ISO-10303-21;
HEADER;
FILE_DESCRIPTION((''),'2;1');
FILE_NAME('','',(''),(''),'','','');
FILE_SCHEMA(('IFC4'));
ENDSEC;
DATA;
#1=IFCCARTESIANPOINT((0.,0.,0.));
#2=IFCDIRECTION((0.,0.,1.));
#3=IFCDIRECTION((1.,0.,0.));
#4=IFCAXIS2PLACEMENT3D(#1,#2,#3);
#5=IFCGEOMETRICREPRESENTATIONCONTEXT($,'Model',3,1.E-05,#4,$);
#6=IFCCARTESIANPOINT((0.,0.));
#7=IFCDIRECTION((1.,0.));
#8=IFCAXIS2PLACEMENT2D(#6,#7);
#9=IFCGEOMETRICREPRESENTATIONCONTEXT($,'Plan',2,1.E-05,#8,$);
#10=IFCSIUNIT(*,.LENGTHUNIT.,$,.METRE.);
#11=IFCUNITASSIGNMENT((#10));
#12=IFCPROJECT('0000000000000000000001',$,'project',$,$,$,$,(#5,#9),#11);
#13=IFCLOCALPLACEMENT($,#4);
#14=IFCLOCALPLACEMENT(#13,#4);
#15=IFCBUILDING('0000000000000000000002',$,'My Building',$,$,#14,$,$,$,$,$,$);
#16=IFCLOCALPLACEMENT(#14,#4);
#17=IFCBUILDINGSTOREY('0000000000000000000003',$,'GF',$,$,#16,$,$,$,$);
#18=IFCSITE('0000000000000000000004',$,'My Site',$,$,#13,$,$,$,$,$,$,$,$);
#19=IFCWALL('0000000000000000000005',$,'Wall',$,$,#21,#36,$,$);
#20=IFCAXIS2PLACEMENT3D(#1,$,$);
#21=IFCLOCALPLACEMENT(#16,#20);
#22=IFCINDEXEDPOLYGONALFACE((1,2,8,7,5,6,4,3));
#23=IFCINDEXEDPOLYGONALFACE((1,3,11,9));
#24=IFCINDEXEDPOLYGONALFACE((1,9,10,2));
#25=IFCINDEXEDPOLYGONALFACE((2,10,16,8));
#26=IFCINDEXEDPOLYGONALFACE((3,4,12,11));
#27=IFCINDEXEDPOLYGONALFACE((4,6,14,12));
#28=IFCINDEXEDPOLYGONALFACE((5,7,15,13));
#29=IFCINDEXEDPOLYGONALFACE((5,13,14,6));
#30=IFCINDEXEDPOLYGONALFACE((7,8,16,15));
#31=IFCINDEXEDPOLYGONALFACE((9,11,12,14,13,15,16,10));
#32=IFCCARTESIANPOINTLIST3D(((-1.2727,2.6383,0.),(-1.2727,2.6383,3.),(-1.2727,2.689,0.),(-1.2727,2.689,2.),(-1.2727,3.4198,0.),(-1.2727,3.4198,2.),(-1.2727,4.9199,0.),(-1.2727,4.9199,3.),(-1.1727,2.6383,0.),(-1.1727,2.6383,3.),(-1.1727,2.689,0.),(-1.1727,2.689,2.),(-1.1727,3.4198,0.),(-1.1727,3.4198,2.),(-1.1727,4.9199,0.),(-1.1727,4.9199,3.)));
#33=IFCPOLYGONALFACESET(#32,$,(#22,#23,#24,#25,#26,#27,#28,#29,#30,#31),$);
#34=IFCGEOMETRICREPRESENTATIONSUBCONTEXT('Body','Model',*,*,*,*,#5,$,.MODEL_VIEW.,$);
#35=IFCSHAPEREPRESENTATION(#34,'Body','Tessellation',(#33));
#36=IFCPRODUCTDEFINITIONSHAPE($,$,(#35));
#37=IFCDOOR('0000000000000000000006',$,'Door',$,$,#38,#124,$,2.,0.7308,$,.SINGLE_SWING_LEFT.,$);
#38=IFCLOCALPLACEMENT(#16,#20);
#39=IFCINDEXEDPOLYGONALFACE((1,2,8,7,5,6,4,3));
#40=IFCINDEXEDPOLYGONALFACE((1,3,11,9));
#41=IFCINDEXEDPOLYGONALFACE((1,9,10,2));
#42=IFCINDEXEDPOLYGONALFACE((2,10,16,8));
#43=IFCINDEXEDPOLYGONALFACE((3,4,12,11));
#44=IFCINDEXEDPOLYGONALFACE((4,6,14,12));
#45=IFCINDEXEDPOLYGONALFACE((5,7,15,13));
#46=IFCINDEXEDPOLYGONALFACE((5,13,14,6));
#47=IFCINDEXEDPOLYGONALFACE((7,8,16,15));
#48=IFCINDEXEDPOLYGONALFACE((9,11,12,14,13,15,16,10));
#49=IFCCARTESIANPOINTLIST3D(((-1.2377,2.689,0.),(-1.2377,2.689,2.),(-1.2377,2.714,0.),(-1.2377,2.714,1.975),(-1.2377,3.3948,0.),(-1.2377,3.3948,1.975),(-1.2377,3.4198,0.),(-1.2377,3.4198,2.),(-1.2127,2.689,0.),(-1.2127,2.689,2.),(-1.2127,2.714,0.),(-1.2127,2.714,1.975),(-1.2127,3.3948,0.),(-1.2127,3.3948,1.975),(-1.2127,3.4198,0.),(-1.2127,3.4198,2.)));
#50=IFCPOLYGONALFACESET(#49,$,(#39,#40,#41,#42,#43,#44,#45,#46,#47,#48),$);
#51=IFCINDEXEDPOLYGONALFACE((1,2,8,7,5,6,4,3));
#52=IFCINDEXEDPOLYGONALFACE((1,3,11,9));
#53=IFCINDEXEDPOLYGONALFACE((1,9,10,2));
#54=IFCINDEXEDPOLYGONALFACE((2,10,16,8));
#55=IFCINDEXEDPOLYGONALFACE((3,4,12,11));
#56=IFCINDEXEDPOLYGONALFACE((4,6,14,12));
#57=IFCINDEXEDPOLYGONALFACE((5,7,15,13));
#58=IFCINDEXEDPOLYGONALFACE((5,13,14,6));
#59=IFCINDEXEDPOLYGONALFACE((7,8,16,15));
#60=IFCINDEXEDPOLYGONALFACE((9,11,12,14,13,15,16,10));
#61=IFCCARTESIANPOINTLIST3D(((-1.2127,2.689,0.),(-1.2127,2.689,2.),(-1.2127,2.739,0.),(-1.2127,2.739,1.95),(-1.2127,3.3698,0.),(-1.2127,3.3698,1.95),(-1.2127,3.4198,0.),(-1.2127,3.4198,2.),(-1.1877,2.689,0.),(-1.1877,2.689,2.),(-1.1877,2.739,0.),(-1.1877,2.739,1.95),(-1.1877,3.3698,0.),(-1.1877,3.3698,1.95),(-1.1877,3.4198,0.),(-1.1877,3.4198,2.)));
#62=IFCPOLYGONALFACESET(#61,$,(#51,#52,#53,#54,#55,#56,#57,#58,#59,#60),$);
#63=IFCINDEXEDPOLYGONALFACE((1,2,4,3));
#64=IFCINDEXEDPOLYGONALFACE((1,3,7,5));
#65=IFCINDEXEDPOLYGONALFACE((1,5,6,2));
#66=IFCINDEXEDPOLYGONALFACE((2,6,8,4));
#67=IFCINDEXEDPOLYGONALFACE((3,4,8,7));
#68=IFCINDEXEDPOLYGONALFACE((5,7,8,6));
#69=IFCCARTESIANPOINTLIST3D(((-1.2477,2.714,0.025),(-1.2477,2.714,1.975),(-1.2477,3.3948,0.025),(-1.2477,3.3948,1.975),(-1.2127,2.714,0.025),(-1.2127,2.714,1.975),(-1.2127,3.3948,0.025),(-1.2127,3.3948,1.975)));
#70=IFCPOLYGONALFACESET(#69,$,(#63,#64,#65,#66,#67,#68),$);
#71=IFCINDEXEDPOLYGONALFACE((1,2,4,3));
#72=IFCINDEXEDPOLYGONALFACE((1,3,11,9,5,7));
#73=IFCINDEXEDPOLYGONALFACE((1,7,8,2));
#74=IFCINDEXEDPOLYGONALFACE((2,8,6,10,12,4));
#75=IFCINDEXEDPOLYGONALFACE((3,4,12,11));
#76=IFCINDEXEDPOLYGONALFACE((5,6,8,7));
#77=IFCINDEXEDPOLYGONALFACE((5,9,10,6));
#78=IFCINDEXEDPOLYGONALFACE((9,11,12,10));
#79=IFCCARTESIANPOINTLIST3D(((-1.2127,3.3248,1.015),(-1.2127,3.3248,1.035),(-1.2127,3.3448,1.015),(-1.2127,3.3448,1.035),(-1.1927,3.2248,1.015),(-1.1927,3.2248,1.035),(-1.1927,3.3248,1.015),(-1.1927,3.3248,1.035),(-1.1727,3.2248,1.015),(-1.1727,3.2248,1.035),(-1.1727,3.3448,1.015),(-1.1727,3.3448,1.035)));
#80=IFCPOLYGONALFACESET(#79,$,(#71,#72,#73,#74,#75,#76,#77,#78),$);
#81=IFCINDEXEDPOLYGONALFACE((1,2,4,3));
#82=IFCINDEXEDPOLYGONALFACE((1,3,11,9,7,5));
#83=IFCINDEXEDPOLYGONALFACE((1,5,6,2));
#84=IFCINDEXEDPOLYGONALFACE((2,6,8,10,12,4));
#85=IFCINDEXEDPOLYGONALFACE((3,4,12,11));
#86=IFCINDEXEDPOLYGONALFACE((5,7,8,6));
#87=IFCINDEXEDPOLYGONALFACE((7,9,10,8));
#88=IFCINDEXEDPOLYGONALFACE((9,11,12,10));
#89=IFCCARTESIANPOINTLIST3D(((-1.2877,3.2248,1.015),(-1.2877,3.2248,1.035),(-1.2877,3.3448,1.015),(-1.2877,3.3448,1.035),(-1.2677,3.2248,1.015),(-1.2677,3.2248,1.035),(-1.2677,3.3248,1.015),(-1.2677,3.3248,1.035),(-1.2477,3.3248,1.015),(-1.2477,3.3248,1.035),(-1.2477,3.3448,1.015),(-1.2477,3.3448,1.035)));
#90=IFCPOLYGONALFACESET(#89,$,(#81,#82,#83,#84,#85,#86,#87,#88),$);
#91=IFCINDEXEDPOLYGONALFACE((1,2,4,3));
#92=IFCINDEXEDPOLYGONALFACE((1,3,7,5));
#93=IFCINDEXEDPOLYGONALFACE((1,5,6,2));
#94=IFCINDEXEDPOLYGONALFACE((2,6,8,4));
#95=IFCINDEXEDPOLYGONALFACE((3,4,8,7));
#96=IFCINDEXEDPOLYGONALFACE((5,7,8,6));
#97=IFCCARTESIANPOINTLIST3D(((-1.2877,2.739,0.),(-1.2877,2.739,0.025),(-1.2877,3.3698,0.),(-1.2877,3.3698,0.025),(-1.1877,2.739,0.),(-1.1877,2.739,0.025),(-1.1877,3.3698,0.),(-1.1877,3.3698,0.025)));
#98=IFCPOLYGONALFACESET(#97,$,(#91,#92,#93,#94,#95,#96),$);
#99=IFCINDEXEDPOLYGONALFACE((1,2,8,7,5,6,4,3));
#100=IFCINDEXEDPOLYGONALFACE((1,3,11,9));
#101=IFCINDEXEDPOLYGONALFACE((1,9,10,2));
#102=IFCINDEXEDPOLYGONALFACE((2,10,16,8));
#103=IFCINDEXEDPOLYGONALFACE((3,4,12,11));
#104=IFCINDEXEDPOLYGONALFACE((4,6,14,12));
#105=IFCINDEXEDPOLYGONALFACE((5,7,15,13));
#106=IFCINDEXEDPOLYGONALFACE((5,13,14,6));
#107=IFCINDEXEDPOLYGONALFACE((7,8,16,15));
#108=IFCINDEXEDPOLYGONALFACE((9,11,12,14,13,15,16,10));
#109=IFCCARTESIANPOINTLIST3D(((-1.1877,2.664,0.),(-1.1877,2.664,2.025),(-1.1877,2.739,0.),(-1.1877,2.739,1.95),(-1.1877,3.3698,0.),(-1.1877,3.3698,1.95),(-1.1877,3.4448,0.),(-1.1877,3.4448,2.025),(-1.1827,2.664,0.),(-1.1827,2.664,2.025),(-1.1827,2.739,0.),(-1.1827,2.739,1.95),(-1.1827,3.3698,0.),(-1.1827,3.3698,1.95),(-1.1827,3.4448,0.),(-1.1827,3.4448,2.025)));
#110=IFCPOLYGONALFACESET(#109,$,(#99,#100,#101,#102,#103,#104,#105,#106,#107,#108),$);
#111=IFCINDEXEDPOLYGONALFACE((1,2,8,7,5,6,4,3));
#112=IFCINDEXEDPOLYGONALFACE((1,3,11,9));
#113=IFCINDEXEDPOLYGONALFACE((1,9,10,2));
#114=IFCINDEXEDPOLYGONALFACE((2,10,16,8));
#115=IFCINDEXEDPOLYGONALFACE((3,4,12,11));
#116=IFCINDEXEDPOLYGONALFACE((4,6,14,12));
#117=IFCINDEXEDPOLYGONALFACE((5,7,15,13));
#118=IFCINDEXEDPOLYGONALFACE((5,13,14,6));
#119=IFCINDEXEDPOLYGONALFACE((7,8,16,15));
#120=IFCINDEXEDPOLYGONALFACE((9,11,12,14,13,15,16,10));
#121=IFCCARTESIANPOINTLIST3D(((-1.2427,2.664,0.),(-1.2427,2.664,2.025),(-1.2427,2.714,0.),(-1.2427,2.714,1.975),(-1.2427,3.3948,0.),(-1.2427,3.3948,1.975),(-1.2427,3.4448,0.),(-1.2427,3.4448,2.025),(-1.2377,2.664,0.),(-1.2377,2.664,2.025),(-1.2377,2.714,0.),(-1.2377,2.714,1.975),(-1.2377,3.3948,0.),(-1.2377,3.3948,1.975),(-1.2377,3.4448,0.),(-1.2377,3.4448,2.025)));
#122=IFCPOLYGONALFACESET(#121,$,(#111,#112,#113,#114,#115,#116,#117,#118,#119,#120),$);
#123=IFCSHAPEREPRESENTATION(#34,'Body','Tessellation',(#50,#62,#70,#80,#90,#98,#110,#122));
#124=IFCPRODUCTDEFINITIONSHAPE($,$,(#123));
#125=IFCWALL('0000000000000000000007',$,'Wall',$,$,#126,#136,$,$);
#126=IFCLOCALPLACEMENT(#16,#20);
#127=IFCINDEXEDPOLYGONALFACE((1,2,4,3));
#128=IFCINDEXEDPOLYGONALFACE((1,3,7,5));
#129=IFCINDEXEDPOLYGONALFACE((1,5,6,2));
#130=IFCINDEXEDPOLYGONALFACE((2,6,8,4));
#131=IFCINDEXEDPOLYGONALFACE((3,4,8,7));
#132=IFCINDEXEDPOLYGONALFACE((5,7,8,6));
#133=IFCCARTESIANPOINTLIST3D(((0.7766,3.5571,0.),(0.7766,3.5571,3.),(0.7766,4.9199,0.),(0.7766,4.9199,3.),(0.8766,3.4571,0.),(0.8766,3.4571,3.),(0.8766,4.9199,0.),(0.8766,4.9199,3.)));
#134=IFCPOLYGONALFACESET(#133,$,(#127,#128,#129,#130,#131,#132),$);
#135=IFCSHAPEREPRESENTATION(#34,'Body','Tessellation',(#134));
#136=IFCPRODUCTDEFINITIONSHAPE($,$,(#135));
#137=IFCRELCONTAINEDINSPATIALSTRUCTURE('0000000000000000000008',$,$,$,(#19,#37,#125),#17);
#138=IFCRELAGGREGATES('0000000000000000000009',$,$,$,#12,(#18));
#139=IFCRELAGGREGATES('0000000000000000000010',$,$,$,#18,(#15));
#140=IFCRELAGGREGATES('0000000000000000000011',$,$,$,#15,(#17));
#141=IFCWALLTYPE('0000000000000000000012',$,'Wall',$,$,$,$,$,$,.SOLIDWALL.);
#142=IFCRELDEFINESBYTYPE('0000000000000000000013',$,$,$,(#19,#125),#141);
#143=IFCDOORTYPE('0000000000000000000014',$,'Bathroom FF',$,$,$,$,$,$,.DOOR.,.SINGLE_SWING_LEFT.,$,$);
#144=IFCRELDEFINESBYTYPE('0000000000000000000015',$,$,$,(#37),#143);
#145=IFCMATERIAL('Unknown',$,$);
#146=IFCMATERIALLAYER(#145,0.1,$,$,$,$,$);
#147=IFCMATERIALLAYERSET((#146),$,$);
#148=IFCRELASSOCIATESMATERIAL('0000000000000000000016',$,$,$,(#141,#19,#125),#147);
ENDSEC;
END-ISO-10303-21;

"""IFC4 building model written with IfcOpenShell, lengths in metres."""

from ifc_helpers import new_model, entity, si_unit, frame, origin_with_axes, origin_2d_with_axis, place, context, subcontext, project, spatial, line, indexed_curve, outline, extrude, shape, source, transform, mapped, material, layer, layer_set, layer_usage, type_object, type_shapes, element, fill, save


model = new_model("IFC4")

# Units and contexts
model_context = context("Model", 3, precision=1e-05, world=origin_with_axes())
plan_context = context("Plan", 2, precision=1e-05, world=origin_2d_with_axis())
body_context_1 = subcontext(model_context, "Body", "Model", "MODEL_VIEW")
body_context_2 = subcontext(plan_context, "Body", "Plan", "PLAN_VIEW")
ifc_project = project(units=[si_unit("LENGTHUNIT", "METRE")], contexts=[model_context, plan_context])

# Site, building, storey
site_placement = place(None, origin_with_axes())
site = spatial("IfcSite", under=ifc_project, at=site_placement, Name="My Site")
building_placement = place(site_placement, origin_with_axes())
building = spatial("IfcBuilding", under=site, at=building_placement, Name="My Building")
storey_placement = place(building_placement, origin_with_axes())
storey = spatial("IfcBuildingStorey", under=building, at=storey_placement, Name="GF")

# Shared definitions
ifc_material_1 = material(Name="Unknown")

# Shared definitions
ifc_layer_1 = layer(ifc_material_1, 0.1)
ifc_layer_set_1 = layer_set([ifc_layer_1])
wall_type = type_object("IfcWallType", Name="Wall", PredefinedType="SOLIDWALL", material=ifc_layer_set_1)

# Wall, opening, door
ifc_layer_usage_1 = layer_usage(ifc_layer_set_1, "AXIS2", "POSITIVE", 0.0)
wall_1_placement = place(storey_placement, frame((-1.1727, 2.6383, 0.0), z_axis=(0.0, 0.0, 1.0), x_axis=(0.0, 1.0, 0.0)))
wall_1 = element("IfcWall", 1, at=wall_1_placement, inside=storey, type_object=wall_type, material=ifc_layer_usage_1, Name="Wall", context=body_context_1, shape_type="SweptSolid", body=[
    extrude(outline(indexed_curve([(0.0, 0.0), (0.0, 0.1), (2.2816, 0.1), (2.2816, 0.0)], segments=[line(1, 2, 3, 4, 1)])), origin_with_axes(), (0.0, 0.0, 1.0), 3.0),
])
shared_shape_1 = source(origin_with_axes(), body_context_1, "Body", "SweptSolid", [
    extrude(outline(indexed_curve([(0.0, 0.0), (0.7308, 0.0), (0.7308, 2.0), (0.0, 2.0)], segments=[line(1, 2, 3, 4, 1)])), frame((0.0, -0.6, 0.0), z_axis=(0.0, -1.0, 0.0), x_axis=(1.0, 0.0, 0.0)), (0.0, 0.0, -1.0), 1.2),
])
opening_1_placement = place(wall_1_placement, frame((0.0507, 0.015, 0.0), z_axis=(0.0, 0.0, 1.0), x_axis=(1.0, 0.0, 0.0)))
opening_1 = element("IfcOpeningElement", 2, at=opening_1_placement, cuts=wall_1, PredefinedType="OPENING", context=body_context_1, shape_type="MappedRepresentation", body=[
    mapped(shared_shape_1, transform((0.0, 0.0, 0.0), x_axis=(1.0, 0.0, 0.0), y_axis=(0.0, 1.0, 0.0), z_axis=(0.0, 0.0, 1.0), scale=1.0)),
])
door_type_1 = type_object("IfcDoorType", Name="Bathroom FF", OperationType="SINGLE_SWING_LEFT", PredefinedType="DOOR")
shared_shape_2 = source(origin_with_axes(), body_context_1, "Body", "SweptSolid", [
    extrude(outline(indexed_curve([(0.0, 0.0), (0.0, 2.0), (0.7308, 2.0), (0.7308, 0.0), (0.7058, 0.0), (0.7058, 1.975), (0.025, 1.975), (0.025, 0.0)], segments=[line(1, 2, 3, 4, 5, 6, 7, 8, 1)])), frame((0.0, 0.025, 0.0), z_axis=(0.0, -1.0, 0.0), x_axis=(1.0, 0.0, 0.0)), (0.0, 0.0, -1.0), 0.025),
    extrude(outline(indexed_curve([(0.0, 0.0), (0.0, 2.0), (0.7308, 2.0), (0.7308, 0.0), (0.6808, 0.0), (0.6808, 1.95), (0.05, 1.95), (0.05, 0.0)], segments=[line(1, 2, 3, 4, 5, 6, 7, 8, 1)])), frame((0.0, 0.0, 0.0), z_axis=(0.0, -1.0, 0.0), x_axis=(1.0, 0.0, 0.0)), (0.0, 0.0, -1.0), 0.025),
    extrude(outline(indexed_curve([(0.0, 0.0), (0.6808, 0.0), (0.6808, 0.035), (0.0, 0.035)], segments=[line(1, 2, 3, 4, 1)])), frame((0.025, 0.025, 0.025), z_axis=(0.0, 0.0, 1.0), x_axis=(1.0, 0.0, 0.0)), (0.0, 0.0, 1.0), 1.95),
    extrude(outline(indexed_curve([(0.0, 0.0), (0.0, -0.04), (-0.12, -0.04), (-0.12, -0.02), (-0.02, -0.02), (-0.02, 0.0)], segments=[line(1, 2, 3, 4, 5, 6, 1)])), frame((0.6558, 0.025, 1.015), z_axis=(0.0, 0.0, 1.0), x_axis=(1.0, 0.0, 0.0)), (0.0, 0.0, 1.0), 0.02),
    extrude(outline(indexed_curve([(0.0, 0.0), (0.0, 0.04), (-0.12, 0.04), (-0.12, 0.02), (-0.02, 0.02), (-0.02, 0.0)], segments=[line(1, 2, 3, 4, 5, 6, 1)])), frame((0.6558, 0.06, 1.015), z_axis=(0.0, 0.0, 1.0), x_axis=(1.0, 0.0, 0.0)), (0.0, 0.0, 1.0), 0.02),
    extrude(outline(indexed_curve([(0.0, 0.0), (0.6308, 0.0), (0.6308, 0.1), (0.0, 0.1)], segments=[line(1, 2, 3, 4, 1)])), frame((0.05, 0.0, 0.0), z_axis=(0.0, 0.0, 1.0), x_axis=(1.0, 0.0, 0.0)), (0.0, 0.0, 1.0), 0.025),
    extrude(outline(indexed_curve([(0.0, 0.0), (0.0, 2.025), (0.7808, 2.025), (0.7808, 0.0), (0.7058, 0.0), (0.7058, 1.95), (0.075, 1.95), (0.075, 0.0)], segments=[line(1, 2, 3, 4, 5, 6, 7, 8, 1)])), frame((-0.025, -0.005, 0.0), z_axis=(0.0, -1.0, 0.0), x_axis=(1.0, 0.0, 0.0)), (0.0, 0.0, -1.0), 0.005),
    extrude(outline(indexed_curve([(0.0, 0.0), (0.0, 2.025), (0.7808, 2.025), (0.7808, 0.0), (0.7308, 0.0), (0.7308, 1.975), (0.05, 1.975), (0.05, 0.0)], segments=[line(1, 2, 3, 4, 5, 6, 7, 8, 1)])), frame((-0.025, 0.05, 0.0), z_axis=(0.0, -1.0, 0.0), x_axis=(1.0, 0.0, 0.0)), (0.0, 0.0, -1.0), 0.005),
])
shared_shape_3 = source(origin_with_axes(), body_context_2, "Body", "Curve2D", [
    entity("IfcIndexedPolyCurve", entity("IfcCartesianPointList2D", [[0.0, 0.0], [0.0, 0.05], [0.025, 0.05], [0.025, 0.025], [0.05, 0.025], [0.05, 0.0]]), [entity("IfcLineIndex", [1, 2, 3, 4, 5, 6, 1])]),
    entity("IfcIndexedPolyCurve", entity("IfcCartesianPointList2D", [[0.7308, 0.0], [0.7308, 0.05], [0.7058, 0.05], [0.7058, 0.025], [0.6808, 0.025], [0.6808, 0.0]]), [entity("IfcLineIndex", [1, 2, 3, 4, 5, 6, 1])]),
    entity("IfcTrimmedCurve", entity("IfcEllipse", entity("IfcAxis2Placement2D", entity("IfcCartesianPoint", [0.06, 0.05]), entity("IfcDirection", [1.0, 0.0])), 0.6458, 0.6808), [entity("IfcCartesianPoint", [0.7058, 0.05])], [entity("IfcCartesianPoint", [0.06, 0.7308])], True, "CARTESIAN"),
    entity("IfcIndexedPolyCurve", entity("IfcCartesianPointList2D", [[0.025, 0.05], [0.06, 0.05], [0.06, 0.7308], [0.025, 0.7308]]), [entity("IfcLineIndex", [1, 2, 3, 4, 1])]),
])
type_shapes(door_type_1, [shared_shape_2, shared_shape_3])
door_1_placement = place(opening_1_placement, frame((0.0, 0.0, 0.0), z_axis=(0.0, 0.0, 1.0), x_axis=(1.0, 0.0, 0.0)))
door_1 = element("IfcDoor", 3, at=door_1_placement, inside=storey, type_object=door_type_1, Name="Door", OperationType="SINGLE_SWING_LEFT", OverallHeight=2.0, OverallWidth=0.7308, shapes=[
    shape(body_context_1, "Body", "MappedRepresentation", [mapped(shared_shape_2, transform((0.0, 0.0, 0.0), x_axis=(1.0, 0.0, 0.0), y_axis=(0.0, 1.0, 0.0), z_axis=(0.0, 0.0, 1.0), scale=1.0))]),
    shape(body_context_2, "Body", "MappedRepresentation", [mapped(shared_shape_3, transform((0.0, 0.0, 0.0), x_axis=(1.0, 0.0, 0.0), y_axis=(0.0, 1.0, 0.0), z_axis=(0.0, 0.0, 1.0), scale=1.0))]),
])
fill(opening_1, door_1)

# Wall
ifc_layer_usage_2 = layer_usage(ifc_layer_set_1, "AXIS2", "POSITIVE", 0.0)
wall_2_placement = place(storey_placement, frame((0.7766, 5.0199, 0.0), z_axis=(0.0, 0.0, 1.0), x_axis=(0.0, -1.0, 0.0)))
element("IfcWall", 4, at=wall_2_placement, inside=storey, type_object=wall_type, material=ifc_layer_usage_2, Name="Wall", context=body_context_1, shape_type="SweptSolid", body=[
    extrude(outline(indexed_curve([(0.1, 0.0), (0.1, 0.1), (1.5628, 0.1), (1.4628, 0.0)], segments=[line(1, 2, 3, 4, 1)])), origin_with_axes(), (0.0, 0.0, 1.0), 3.0),
])

save(model, "model.ifc")
